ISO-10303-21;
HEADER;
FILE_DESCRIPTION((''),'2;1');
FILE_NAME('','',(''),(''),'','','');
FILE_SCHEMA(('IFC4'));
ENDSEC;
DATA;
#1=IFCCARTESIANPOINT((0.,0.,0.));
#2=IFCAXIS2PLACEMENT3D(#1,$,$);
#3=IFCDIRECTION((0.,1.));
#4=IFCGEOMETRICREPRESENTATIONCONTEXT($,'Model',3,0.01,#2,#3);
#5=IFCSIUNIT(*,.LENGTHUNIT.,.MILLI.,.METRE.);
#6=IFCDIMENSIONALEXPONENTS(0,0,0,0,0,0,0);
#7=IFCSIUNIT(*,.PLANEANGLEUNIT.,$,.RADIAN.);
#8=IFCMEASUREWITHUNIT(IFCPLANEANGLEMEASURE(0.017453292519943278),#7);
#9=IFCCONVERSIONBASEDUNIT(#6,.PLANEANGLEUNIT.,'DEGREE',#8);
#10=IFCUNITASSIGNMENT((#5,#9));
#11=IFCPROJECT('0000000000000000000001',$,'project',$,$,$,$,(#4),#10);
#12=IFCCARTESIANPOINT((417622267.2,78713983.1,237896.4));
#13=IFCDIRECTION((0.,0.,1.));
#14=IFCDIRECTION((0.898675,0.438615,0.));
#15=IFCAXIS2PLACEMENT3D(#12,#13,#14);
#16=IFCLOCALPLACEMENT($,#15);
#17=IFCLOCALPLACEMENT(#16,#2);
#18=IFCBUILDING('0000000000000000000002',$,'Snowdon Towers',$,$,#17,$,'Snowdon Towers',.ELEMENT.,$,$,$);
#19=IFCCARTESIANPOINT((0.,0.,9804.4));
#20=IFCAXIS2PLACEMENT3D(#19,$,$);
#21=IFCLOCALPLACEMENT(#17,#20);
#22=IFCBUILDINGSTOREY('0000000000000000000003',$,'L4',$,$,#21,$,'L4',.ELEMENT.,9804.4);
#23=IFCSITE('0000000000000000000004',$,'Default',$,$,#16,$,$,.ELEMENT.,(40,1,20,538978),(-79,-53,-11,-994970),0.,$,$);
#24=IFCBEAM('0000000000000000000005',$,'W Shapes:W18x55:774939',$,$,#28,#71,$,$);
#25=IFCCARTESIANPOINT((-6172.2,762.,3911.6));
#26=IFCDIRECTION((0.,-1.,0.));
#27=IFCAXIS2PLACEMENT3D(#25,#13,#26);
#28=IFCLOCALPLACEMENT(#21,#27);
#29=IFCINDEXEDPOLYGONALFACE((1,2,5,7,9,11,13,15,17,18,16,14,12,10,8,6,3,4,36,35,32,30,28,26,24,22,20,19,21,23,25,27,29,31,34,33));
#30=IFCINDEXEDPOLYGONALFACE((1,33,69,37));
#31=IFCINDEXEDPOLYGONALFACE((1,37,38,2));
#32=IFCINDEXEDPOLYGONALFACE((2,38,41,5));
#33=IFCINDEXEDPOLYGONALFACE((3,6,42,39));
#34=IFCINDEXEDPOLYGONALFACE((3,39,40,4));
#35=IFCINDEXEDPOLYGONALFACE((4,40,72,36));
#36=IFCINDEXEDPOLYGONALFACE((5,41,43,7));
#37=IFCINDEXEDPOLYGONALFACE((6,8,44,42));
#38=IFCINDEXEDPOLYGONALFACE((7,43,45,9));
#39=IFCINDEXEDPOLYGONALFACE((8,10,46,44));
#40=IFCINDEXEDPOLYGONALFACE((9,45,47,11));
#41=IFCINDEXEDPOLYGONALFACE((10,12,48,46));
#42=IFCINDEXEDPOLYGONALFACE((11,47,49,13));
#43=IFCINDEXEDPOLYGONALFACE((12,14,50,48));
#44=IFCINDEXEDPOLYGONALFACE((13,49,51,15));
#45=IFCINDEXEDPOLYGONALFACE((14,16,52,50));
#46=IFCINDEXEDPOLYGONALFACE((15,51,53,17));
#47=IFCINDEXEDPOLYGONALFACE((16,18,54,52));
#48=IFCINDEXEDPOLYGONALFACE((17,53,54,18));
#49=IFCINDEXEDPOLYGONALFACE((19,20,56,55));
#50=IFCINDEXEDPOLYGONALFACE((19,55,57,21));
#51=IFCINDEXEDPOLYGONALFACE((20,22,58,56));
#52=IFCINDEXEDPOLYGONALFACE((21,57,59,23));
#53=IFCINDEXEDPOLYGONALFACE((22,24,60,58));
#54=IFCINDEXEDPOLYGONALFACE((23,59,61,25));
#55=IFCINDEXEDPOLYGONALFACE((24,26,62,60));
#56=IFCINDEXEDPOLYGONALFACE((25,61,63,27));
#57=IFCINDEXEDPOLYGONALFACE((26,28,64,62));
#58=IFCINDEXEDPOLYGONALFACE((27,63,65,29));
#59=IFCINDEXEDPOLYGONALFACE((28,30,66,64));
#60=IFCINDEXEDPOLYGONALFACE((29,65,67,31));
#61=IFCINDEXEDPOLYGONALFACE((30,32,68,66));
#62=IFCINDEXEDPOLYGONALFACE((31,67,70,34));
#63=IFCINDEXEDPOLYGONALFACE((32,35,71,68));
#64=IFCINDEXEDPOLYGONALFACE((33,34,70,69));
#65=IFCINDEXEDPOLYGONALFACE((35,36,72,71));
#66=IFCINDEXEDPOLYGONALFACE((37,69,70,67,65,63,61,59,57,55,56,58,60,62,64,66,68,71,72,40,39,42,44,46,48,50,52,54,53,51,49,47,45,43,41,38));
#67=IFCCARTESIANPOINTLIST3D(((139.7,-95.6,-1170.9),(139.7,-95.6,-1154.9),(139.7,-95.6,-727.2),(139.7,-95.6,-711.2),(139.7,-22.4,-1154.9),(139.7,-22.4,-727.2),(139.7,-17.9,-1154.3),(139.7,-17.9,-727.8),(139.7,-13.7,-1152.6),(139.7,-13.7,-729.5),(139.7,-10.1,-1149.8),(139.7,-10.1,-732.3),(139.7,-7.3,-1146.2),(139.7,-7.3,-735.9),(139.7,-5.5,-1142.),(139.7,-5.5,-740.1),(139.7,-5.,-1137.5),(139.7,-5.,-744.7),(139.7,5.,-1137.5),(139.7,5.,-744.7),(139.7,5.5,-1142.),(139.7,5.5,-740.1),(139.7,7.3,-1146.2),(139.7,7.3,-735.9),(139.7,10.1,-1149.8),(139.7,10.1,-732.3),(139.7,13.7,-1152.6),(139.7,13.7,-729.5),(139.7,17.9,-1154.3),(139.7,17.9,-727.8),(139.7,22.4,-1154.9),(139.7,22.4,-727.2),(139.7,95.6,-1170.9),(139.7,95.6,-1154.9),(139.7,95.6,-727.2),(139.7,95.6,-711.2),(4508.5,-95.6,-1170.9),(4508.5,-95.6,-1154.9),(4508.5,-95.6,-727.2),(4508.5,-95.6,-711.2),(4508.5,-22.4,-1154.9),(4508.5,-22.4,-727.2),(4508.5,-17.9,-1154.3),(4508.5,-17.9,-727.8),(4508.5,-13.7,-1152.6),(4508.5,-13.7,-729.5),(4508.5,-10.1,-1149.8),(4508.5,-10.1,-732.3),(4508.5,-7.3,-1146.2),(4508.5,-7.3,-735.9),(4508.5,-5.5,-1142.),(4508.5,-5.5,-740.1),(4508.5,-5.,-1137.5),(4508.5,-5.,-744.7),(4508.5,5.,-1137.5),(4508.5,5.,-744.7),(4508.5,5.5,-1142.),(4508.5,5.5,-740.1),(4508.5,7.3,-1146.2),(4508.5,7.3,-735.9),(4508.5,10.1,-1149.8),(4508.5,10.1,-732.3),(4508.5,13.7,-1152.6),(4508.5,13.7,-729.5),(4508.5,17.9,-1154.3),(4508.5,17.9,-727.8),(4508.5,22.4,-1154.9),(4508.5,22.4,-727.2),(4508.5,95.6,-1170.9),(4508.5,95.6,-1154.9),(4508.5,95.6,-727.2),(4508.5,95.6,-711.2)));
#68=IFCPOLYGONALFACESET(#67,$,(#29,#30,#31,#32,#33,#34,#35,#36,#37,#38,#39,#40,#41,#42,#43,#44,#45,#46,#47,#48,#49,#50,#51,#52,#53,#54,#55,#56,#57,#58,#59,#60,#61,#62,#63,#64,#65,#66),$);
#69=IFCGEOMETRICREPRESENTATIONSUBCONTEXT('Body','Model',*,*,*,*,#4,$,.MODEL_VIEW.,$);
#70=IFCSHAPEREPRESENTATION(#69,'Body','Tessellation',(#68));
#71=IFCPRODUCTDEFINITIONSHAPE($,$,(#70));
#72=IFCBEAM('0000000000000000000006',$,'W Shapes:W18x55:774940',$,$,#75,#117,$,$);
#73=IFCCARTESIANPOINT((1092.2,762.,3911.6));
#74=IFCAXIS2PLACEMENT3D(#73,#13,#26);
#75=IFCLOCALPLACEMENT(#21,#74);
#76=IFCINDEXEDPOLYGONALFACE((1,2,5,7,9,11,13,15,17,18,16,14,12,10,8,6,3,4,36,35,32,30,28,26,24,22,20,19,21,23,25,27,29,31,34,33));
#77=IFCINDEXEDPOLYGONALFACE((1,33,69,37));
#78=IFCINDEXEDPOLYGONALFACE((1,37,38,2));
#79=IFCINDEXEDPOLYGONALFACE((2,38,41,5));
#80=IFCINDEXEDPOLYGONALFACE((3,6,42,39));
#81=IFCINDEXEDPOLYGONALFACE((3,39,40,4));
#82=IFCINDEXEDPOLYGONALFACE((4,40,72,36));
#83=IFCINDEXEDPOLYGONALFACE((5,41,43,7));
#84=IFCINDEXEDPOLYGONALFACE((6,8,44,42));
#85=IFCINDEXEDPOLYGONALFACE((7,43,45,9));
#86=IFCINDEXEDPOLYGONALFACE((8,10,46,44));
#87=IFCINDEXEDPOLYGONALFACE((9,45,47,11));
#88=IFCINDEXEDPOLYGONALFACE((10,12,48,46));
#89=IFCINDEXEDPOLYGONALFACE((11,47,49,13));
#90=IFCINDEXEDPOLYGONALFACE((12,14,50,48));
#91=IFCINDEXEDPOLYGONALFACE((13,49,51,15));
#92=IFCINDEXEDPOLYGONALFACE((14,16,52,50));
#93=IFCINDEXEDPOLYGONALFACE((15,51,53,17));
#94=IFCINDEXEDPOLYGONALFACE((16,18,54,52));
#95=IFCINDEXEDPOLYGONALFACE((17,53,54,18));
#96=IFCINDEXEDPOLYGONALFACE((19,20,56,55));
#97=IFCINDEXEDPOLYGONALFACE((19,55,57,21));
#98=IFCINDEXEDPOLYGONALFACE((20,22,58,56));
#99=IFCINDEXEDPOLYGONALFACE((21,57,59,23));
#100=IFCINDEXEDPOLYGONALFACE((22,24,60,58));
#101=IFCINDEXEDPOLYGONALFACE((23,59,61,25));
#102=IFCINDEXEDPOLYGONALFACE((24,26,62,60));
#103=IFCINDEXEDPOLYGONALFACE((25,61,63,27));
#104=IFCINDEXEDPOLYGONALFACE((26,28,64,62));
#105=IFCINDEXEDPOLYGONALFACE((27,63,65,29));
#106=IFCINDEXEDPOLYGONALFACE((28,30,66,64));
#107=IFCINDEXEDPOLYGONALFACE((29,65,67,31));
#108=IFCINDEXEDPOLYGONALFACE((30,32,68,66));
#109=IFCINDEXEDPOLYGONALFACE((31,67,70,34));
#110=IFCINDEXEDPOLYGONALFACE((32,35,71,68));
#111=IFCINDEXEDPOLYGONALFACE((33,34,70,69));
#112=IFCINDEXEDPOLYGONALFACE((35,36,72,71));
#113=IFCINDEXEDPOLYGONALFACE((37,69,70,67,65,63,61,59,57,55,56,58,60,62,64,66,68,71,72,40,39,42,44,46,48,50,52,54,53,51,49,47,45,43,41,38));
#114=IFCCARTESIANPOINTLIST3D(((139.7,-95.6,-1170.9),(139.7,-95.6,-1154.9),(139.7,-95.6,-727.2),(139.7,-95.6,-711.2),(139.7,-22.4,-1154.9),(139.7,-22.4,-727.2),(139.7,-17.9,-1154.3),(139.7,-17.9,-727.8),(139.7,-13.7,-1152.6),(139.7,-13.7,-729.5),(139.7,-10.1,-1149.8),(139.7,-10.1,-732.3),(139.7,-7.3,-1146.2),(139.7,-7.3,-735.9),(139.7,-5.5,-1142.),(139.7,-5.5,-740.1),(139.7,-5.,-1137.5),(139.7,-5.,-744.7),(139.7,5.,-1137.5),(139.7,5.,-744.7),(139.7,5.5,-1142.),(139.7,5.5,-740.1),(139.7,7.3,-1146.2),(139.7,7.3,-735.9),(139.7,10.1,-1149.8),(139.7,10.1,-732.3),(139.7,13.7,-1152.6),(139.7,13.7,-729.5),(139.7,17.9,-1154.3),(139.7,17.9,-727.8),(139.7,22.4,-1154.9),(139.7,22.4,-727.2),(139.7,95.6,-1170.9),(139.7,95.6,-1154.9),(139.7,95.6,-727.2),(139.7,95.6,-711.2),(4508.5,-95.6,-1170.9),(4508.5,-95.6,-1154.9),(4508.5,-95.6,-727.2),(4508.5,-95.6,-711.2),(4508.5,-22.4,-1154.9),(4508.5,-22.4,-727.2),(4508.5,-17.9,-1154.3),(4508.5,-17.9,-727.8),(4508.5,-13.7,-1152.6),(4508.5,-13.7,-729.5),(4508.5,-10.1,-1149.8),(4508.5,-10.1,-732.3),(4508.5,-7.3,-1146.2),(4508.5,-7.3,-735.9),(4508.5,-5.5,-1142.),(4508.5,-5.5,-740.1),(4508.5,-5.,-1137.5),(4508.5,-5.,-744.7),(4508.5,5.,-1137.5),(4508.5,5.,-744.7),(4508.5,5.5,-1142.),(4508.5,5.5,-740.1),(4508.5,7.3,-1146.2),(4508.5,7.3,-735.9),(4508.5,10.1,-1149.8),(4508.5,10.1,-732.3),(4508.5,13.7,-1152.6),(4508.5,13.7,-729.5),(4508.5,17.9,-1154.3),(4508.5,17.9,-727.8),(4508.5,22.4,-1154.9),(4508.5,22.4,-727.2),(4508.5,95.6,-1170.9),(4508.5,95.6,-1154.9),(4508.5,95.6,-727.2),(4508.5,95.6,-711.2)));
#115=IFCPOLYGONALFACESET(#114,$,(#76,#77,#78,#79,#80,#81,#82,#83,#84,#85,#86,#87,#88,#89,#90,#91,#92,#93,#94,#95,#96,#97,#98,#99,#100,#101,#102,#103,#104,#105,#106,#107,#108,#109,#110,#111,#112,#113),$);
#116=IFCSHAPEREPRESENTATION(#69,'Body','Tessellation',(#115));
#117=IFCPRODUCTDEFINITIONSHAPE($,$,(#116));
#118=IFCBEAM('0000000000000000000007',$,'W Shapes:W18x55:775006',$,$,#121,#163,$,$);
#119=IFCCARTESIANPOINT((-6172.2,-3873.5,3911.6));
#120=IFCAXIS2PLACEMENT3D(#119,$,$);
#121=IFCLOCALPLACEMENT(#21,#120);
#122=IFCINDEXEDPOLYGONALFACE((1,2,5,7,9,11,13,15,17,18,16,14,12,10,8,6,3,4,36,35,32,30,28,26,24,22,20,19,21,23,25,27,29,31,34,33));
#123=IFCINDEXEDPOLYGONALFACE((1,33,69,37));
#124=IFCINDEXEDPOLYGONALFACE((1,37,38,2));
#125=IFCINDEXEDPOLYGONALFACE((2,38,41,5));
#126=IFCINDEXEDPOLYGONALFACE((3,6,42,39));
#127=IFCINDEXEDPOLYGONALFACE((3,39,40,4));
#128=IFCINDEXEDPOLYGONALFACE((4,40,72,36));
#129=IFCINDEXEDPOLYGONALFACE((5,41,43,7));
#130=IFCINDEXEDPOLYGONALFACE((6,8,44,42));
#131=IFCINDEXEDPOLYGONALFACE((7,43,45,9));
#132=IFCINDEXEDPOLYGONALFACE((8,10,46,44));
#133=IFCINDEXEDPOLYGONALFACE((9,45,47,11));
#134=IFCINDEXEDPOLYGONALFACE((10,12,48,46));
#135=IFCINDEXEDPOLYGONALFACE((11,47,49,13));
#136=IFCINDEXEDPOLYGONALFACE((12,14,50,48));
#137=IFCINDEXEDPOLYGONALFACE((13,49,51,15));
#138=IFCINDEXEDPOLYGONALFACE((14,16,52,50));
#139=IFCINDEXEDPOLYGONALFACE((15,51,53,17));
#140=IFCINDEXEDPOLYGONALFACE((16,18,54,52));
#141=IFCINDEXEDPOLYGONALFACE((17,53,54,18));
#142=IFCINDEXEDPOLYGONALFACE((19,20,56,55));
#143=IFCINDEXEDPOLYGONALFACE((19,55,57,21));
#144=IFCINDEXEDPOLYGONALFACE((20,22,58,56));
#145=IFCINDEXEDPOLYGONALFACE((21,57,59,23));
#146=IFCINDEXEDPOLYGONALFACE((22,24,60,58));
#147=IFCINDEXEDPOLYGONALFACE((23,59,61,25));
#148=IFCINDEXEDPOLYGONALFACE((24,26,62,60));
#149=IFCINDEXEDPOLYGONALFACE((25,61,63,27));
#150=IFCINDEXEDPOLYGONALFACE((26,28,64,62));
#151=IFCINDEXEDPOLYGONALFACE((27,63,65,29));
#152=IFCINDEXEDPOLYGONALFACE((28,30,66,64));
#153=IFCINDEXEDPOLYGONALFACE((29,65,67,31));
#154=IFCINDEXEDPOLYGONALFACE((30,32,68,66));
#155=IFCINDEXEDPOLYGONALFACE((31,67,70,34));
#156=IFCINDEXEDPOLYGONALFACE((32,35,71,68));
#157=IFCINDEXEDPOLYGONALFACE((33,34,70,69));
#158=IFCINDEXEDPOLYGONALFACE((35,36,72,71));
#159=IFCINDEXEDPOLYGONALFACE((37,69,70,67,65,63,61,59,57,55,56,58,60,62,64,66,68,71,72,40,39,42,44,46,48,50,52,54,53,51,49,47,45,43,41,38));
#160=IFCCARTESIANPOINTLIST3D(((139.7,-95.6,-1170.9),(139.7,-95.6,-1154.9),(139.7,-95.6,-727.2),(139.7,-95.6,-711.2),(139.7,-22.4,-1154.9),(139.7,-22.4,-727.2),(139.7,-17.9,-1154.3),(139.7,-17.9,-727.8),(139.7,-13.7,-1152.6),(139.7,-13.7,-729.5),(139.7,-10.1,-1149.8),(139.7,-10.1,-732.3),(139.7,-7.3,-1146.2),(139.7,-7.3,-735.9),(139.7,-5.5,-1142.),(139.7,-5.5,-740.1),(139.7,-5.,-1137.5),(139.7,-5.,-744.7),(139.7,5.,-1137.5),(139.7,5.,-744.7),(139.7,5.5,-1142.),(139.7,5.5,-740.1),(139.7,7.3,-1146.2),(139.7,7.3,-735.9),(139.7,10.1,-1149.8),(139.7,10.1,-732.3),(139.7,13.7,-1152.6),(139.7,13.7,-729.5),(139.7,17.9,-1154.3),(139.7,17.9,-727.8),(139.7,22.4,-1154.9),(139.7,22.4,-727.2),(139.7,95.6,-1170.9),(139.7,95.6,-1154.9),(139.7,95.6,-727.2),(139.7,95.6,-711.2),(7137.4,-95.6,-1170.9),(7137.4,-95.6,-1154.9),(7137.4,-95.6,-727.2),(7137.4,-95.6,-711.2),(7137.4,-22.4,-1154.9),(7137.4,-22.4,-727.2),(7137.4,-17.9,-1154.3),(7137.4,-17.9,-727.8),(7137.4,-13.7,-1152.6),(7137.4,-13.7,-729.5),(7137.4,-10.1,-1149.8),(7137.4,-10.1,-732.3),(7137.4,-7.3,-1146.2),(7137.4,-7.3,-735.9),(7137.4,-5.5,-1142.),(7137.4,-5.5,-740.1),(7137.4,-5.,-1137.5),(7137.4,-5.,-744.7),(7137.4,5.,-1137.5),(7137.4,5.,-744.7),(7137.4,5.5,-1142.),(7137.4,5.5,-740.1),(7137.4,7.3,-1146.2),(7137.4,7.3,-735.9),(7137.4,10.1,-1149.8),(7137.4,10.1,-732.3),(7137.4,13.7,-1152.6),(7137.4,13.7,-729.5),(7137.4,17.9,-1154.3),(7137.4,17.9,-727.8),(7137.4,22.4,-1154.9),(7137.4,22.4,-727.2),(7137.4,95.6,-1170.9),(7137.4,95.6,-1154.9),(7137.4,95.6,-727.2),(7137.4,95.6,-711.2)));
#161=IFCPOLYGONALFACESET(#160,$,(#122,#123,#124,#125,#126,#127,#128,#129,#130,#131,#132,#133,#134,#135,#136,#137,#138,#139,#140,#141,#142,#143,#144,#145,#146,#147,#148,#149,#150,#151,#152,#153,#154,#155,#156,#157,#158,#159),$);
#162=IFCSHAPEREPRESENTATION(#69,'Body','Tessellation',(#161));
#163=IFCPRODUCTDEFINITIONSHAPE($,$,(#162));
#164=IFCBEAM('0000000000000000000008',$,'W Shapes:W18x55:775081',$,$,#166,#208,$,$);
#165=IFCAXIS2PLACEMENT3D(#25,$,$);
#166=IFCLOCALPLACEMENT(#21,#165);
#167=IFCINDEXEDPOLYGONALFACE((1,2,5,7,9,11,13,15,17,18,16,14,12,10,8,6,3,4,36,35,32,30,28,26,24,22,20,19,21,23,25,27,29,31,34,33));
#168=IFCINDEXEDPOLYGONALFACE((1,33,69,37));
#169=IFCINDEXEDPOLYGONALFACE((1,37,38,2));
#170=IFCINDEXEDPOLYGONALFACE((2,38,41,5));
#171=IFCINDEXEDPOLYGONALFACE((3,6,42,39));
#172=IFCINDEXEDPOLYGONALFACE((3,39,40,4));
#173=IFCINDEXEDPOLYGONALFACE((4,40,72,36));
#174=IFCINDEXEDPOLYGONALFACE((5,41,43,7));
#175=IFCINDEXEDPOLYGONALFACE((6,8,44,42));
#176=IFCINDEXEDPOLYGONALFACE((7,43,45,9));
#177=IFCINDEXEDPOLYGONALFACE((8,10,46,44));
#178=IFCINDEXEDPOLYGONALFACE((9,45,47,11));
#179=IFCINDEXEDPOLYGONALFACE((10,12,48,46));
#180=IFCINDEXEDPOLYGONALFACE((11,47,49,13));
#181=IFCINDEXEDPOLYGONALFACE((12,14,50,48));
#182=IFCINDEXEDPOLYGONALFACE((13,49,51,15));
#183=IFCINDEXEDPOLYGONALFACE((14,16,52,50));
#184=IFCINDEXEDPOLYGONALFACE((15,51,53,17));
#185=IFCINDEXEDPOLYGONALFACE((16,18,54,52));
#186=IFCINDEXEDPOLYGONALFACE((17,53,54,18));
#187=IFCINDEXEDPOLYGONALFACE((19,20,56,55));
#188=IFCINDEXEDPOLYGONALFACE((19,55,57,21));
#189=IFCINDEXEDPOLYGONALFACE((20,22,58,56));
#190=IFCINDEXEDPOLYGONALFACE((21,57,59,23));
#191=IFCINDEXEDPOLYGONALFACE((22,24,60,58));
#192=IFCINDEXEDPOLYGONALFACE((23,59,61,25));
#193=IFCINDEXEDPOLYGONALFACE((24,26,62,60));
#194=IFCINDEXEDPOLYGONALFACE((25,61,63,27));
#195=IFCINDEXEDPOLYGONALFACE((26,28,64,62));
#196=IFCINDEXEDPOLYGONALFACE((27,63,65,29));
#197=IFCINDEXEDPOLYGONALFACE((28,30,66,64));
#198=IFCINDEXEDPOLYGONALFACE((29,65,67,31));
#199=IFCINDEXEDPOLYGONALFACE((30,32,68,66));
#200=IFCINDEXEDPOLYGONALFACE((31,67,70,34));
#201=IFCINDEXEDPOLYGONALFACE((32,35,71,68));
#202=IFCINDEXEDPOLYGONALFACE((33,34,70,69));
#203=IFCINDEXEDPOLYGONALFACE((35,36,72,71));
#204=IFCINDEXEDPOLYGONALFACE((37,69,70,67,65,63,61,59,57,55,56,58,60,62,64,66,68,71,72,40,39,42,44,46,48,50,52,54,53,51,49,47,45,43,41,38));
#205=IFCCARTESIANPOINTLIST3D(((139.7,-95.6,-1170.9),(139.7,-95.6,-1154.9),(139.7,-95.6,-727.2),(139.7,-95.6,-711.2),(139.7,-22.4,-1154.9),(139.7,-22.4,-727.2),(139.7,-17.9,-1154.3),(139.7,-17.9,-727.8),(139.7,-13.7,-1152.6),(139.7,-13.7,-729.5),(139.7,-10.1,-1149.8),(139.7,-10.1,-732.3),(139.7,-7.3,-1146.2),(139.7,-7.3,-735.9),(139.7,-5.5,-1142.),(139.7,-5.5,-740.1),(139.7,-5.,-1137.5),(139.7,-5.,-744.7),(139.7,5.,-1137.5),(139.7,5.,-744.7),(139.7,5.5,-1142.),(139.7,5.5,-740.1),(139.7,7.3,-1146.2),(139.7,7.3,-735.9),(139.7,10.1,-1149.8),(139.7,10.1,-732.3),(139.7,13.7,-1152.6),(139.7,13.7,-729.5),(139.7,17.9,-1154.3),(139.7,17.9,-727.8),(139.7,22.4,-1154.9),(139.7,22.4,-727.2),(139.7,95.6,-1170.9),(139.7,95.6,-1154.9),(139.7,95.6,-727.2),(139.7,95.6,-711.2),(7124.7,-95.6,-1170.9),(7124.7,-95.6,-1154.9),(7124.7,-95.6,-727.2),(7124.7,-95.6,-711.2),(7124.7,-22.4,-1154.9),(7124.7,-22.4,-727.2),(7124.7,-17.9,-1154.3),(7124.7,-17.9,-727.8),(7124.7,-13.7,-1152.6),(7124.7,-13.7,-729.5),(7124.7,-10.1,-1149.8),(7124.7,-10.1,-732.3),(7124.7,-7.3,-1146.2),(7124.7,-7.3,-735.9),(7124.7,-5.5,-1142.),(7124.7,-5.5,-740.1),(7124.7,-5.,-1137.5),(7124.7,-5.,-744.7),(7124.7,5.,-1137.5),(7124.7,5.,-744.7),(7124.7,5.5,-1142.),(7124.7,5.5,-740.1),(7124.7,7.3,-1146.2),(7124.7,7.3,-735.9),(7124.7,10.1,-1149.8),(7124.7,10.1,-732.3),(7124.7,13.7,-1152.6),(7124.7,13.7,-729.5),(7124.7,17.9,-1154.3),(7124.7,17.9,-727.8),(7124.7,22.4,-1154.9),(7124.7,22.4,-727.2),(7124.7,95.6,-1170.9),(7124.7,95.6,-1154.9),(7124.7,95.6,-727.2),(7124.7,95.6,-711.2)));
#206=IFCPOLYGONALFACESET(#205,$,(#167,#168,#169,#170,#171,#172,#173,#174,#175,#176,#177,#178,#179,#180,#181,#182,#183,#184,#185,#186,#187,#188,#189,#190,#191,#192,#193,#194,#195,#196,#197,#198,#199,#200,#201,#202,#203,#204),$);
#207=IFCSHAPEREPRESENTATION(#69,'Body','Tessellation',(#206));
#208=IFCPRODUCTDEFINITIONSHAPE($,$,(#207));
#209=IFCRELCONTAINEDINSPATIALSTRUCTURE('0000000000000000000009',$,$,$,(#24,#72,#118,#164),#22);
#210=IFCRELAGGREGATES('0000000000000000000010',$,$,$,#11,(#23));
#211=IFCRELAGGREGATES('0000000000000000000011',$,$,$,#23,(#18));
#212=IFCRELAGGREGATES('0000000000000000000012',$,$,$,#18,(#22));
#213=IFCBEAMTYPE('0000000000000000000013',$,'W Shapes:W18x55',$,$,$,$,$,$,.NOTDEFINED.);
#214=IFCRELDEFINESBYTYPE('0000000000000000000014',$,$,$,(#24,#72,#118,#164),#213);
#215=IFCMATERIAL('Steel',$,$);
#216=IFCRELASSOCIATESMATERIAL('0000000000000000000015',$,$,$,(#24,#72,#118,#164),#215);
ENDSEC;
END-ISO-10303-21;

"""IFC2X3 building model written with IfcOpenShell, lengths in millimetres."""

from ifc_helpers import new_model, entity, si_unit, converted_unit, direction, frame, frame_2d, origin, place, context, subcontext, project, spatial, i_section, extrude, material, type_object, element, save


model = new_model("IFC2X3")

# Units and contexts
model_context = context("Model", 3, precision=0.01, world=origin(), true_north=direction((0.0, 1.0)))
body_context = subcontext(model_context, "Body", "Model", "MODEL_VIEW")
ifc_project = project(units=[si_unit("LENGTHUNIT", "METRE", prefix="MILLI"), converted_unit("PLANEANGLEUNIT", "DEGREE", entity("IfcPlaneAngleMeasure", 0.017453292519943278), si_unit("PLANEANGLEUNIT", "RADIAN"), dimensions=[0, 0, 0, 0, 0, 0, 0])], contexts=[model_context])

# Site, building, storey
site_placement = place(None, frame((417622267.2, 78713983.1, 237896.4), z_axis=(0.0, 0.0, 1.0), x_axis=(0.898675, 0.438615, 0.0)))
site = spatial("IfcSite", under=ifc_project, at=site_placement, Name="Default", CompositionType="ELEMENT", RefLatitude=(40, 1, 20, 538978), RefLongitude=(-79, -53, -11, -994970), RefElevation=0.0)
building_placement = place(site_placement, origin())
building = spatial("IfcBuilding", under=site, at=building_placement, Name="Snowdon Towers", LongName="Snowdon Towers", CompositionType="ELEMENT")
storey_placement = place(building_placement, frame((0.0, 0.0, 9804.4)))
storey = spatial("IfcBuildingStorey", under=building, at=storey_placement, Name="L4", LongName="L4", CompositionType="ELEMENT", Elevation=9804.4)

# Shared definitions
ifc_material_1 = material(Name="Steel")

# Beams
beam_type_1 = type_object("IfcBeamType", Name="W Shapes:W18x55", PredefinedType="NOTDEFINED")
beam_1_placement = place(storey_placement, frame((-6172.2, 762.0, 3911.6), z_axis=(0.0, 0.0, 1.0), x_axis=(0.0, -1.0, 0.0)))
element("IfcBeam", 1, at=beam_1_placement, inside=storey, type_object=beam_type_1, material=ifc_material_1, Name="W Shapes:W18x55:774939", context=body_context, shape_type="SweptSolid", body=[
    extrude(i_section(OverallWidth=191.3, OverallDepth=459.7, WebThickness=9.9, FlangeThickness=16.0, FilletRadius=17.5, at=frame_2d((0.0, 0.0), x_axis=(0.0, 1.0))), frame((139.7, 0.0, -941.1), z_axis=(1.0, 0.0, 0.0), x_axis=(0.0, 0.0, -1.0)), (0.0, 0.0, 1.0), 4368.8),
])
beam_2_placement = place(storey_placement, frame((1092.2, 762.0, 3911.6), z_axis=(0.0, 0.0, 1.0), x_axis=(0.0, -1.0, 0.0)))
element("IfcBeam", 2, at=beam_2_placement, inside=storey, type_object=beam_type_1, material=ifc_material_1, Name="W Shapes:W18x55:774940", context=body_context, shape_type="SweptSolid", body=[
    extrude(i_section(OverallWidth=191.3, OverallDepth=459.7, WebThickness=9.9, FlangeThickness=16.0, FilletRadius=17.5, at=frame_2d((0.0, 0.0), x_axis=(0.0, 1.0))), frame((139.7, 0.0, -941.1), z_axis=(1.0, 0.0, 0.0), x_axis=(0.0, 0.0, -1.0)), (0.0, 0.0, 1.0), 4368.8),
])
beam_3_placement = place(storey_placement, frame((-6172.2, -3873.5, 3911.6)))
element("IfcBeam", 3, at=beam_3_placement, inside=storey, type_object=beam_type_1, material=ifc_material_1, Name="W Shapes:W18x55:775006", context=body_context, shape_type="SweptSolid", body=[
    extrude(i_section(OverallWidth=191.3, OverallDepth=459.7, WebThickness=9.9, FlangeThickness=16.0, FilletRadius=17.5, at=frame_2d((0.0, 0.0), x_axis=(0.0, 1.0))), frame((139.7, 0.0, -941.1), z_axis=(1.0, 0.0, 0.0), x_axis=(0.0, 0.0, -1.0)), (0.0, 0.0, 1.0), 6997.7),
])
beam_4_placement = place(storey_placement, frame((-6172.2, 762.0, 3911.6)))
element("IfcBeam", 4, at=beam_4_placement, inside=storey, type_object=beam_type_1, material=ifc_material_1, Name="W Shapes:W18x55:775081", context=body_context, shape_type="SweptSolid", body=[
    extrude(i_section(OverallWidth=191.3, OverallDepth=459.7, WebThickness=9.9, FlangeThickness=16.0, FilletRadius=17.5, at=frame_2d((0.0, 0.0), x_axis=(0.0, 1.0))), frame((139.7, 0.0, -941.1), z_axis=(1.0, 0.0, 0.0), x_axis=(0.0, 0.0, -1.0)), (0.0, 0.0, 1.0), 6985.0),
])

save(model, "model.ifc")
